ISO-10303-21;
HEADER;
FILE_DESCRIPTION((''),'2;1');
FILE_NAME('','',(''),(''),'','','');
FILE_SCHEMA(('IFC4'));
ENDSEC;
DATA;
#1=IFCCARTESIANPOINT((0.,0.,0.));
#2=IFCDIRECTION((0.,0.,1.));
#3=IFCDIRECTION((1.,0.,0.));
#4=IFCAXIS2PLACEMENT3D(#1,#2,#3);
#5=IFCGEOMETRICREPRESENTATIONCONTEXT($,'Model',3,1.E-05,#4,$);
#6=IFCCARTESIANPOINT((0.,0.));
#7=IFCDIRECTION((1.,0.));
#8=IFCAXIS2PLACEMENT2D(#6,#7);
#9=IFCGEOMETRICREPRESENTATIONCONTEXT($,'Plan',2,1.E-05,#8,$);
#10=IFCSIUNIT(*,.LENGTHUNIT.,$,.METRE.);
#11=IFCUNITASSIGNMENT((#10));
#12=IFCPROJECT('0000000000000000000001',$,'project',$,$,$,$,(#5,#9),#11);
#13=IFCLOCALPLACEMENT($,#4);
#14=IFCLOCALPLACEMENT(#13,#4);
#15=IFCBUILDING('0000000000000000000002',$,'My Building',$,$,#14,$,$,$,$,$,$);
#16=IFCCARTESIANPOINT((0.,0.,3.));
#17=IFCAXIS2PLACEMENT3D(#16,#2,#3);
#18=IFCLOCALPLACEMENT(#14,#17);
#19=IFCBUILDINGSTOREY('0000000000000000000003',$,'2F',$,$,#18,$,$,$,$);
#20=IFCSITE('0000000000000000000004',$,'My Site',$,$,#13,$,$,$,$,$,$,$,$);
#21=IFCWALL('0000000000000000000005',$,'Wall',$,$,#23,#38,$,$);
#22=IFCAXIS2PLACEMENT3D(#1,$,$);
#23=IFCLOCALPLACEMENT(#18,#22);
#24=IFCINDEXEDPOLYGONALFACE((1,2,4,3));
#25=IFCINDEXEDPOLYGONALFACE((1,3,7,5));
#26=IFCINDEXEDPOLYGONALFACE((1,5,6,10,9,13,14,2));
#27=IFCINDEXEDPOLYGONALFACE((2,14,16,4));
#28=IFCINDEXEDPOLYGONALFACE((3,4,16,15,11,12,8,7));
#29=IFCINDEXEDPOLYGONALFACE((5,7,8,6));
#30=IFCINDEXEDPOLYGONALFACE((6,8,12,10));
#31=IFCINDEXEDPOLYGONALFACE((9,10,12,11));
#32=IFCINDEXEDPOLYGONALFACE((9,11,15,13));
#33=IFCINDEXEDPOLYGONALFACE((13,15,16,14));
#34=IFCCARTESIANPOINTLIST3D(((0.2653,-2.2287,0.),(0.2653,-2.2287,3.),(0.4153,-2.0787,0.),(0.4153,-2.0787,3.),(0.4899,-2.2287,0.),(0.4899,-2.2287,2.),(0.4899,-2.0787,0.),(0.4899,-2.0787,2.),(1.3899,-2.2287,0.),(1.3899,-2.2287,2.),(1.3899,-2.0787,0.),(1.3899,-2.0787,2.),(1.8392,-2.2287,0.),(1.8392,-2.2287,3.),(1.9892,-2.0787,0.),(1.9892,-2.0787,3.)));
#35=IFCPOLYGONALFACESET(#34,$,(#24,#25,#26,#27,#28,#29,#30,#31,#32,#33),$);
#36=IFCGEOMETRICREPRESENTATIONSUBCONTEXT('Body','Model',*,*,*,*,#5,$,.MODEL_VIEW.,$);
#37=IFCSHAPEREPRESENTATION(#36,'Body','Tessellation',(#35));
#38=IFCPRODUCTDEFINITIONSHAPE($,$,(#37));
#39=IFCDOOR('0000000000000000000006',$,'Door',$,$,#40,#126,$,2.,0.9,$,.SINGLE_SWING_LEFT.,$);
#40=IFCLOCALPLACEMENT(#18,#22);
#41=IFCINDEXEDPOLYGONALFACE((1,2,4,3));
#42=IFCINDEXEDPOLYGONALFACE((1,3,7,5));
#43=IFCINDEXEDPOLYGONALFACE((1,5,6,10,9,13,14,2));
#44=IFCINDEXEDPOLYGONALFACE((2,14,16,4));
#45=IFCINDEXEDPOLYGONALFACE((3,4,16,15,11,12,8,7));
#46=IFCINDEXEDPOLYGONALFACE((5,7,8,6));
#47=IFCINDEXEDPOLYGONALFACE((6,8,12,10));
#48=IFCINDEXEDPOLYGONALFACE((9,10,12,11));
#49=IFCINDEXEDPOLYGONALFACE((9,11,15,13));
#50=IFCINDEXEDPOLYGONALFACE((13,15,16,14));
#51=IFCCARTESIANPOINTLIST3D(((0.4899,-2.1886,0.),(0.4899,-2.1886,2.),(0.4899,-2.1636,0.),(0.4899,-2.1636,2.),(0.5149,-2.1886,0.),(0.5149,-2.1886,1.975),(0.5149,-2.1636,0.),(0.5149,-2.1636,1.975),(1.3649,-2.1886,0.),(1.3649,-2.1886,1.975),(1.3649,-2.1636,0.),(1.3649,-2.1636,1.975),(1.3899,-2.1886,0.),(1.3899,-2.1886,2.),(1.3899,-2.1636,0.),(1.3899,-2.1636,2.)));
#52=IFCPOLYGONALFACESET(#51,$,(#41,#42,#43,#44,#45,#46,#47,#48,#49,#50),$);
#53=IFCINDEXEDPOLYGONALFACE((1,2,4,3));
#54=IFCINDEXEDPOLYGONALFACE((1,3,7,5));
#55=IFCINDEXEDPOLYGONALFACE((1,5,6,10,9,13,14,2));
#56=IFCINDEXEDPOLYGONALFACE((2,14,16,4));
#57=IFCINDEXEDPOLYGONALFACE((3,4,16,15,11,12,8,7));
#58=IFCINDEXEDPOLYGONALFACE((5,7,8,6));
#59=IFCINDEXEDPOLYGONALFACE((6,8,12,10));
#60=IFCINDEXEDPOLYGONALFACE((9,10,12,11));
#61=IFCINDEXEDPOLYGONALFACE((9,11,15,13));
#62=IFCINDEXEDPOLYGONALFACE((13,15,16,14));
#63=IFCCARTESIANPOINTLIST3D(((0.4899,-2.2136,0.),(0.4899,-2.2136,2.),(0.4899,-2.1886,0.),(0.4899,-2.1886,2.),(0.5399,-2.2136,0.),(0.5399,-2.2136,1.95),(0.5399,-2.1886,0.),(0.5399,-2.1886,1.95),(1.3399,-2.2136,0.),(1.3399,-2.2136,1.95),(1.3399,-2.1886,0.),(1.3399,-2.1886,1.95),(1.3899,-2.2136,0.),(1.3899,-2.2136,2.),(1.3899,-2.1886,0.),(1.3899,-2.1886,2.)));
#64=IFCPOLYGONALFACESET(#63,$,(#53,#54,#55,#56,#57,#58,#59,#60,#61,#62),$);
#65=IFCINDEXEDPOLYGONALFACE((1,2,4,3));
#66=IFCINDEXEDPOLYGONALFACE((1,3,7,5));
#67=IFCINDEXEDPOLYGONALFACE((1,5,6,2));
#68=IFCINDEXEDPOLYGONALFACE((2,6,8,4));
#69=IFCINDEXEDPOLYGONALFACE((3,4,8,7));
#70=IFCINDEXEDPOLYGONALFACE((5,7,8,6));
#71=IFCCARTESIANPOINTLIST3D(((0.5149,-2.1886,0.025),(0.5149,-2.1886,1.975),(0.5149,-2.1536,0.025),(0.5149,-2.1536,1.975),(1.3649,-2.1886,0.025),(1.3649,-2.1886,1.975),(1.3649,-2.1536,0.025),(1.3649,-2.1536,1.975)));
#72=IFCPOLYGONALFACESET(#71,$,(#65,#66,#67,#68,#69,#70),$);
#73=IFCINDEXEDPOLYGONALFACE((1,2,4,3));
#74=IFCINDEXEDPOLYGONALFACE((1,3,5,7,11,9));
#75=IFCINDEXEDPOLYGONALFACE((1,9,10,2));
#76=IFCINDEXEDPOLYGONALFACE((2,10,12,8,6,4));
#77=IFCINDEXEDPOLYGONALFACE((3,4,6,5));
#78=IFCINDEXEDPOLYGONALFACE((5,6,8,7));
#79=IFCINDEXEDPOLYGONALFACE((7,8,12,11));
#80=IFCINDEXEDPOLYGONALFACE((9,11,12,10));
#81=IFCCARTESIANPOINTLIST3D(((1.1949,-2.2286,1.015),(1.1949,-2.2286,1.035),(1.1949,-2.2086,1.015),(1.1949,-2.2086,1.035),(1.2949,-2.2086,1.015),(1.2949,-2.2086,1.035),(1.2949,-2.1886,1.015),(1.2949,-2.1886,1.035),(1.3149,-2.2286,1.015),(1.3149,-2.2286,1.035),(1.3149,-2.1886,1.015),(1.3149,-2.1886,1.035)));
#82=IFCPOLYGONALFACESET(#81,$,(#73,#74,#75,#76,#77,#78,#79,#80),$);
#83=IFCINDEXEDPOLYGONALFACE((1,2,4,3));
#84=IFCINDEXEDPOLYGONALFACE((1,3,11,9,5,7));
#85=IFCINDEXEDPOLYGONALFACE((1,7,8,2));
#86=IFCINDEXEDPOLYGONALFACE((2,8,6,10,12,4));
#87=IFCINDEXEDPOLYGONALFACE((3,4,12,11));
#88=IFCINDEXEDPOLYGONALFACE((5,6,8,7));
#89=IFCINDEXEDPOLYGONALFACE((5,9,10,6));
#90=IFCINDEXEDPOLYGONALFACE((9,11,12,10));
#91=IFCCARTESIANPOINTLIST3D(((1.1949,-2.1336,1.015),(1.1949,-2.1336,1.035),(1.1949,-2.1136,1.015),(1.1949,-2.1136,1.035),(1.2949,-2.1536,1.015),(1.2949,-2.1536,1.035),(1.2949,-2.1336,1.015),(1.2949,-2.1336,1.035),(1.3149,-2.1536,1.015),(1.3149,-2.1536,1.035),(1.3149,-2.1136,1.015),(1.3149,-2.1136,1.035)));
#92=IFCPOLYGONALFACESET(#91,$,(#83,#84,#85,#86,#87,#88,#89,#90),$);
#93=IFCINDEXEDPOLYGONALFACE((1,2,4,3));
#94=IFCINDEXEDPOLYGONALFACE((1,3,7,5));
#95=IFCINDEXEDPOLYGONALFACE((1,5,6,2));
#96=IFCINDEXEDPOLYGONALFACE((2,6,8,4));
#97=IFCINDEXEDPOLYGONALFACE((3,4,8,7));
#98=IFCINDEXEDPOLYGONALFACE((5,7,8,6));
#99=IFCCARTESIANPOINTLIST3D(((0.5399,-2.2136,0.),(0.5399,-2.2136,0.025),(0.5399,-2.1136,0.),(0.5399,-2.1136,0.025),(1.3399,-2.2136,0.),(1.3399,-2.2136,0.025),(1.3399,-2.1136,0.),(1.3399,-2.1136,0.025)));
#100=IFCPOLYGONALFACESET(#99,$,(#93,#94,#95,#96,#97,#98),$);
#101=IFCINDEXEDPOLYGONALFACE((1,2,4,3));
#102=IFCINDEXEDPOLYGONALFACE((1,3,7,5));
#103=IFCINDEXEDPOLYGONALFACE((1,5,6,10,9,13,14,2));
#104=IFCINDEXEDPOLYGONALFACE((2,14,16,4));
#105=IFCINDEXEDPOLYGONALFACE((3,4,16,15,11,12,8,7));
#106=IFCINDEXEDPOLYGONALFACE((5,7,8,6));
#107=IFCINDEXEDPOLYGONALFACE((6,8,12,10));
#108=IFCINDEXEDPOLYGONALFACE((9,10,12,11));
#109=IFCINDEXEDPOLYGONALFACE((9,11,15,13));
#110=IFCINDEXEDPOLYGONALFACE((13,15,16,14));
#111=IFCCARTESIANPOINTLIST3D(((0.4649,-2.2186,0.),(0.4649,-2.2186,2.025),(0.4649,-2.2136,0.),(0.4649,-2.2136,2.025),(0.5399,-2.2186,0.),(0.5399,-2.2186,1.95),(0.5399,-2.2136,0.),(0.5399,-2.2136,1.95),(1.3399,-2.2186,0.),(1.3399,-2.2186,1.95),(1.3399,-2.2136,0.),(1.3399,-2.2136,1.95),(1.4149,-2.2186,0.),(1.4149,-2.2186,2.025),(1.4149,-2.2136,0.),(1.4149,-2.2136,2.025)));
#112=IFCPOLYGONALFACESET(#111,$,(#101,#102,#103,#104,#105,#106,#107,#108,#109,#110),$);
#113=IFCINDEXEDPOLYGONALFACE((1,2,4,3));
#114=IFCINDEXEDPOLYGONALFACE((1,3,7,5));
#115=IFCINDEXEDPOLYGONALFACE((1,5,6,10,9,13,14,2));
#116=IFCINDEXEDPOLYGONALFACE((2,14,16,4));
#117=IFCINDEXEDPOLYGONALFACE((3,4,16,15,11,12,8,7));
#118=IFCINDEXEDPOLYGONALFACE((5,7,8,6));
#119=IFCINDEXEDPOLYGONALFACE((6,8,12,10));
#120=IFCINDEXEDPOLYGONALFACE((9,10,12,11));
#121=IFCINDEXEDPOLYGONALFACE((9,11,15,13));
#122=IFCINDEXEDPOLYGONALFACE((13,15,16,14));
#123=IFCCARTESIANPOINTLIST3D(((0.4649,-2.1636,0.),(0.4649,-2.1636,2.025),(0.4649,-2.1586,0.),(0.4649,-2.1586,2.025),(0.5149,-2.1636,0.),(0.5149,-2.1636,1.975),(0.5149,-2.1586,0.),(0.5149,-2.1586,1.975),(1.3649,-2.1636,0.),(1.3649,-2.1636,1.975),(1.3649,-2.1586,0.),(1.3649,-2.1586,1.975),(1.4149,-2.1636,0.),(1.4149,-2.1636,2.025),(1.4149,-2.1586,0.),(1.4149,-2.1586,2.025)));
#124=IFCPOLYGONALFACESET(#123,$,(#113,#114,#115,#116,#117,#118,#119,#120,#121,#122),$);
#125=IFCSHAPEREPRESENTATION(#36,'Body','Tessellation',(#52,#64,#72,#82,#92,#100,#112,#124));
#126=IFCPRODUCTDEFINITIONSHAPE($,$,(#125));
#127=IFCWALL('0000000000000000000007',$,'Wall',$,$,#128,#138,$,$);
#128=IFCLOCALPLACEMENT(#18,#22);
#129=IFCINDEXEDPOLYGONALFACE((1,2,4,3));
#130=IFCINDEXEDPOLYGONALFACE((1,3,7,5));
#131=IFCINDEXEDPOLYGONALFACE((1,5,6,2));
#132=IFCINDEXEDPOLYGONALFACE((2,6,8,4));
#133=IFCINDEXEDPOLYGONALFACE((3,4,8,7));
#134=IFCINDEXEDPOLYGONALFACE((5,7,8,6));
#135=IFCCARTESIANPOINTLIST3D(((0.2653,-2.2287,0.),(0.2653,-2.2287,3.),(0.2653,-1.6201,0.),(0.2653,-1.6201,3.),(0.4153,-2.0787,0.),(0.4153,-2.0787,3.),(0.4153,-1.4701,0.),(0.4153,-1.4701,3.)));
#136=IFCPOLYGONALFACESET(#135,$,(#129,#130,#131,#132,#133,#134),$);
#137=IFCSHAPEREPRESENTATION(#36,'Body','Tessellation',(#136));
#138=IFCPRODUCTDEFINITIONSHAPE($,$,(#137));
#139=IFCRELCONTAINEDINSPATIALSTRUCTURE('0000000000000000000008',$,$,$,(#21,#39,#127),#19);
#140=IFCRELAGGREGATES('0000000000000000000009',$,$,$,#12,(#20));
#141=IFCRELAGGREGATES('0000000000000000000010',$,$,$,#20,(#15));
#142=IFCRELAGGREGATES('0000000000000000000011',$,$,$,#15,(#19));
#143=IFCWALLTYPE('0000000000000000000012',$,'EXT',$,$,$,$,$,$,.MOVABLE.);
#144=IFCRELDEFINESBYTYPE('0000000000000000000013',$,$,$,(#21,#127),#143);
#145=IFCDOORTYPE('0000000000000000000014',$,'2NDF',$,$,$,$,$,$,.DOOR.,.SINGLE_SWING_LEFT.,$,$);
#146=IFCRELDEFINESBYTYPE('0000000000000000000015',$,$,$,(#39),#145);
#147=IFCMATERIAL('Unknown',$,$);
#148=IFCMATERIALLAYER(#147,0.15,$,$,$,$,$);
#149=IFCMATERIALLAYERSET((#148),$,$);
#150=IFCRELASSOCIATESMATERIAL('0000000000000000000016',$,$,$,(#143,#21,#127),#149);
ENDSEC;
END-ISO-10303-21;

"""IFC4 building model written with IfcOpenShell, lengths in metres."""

from ifc_helpers import new_model, entity, si_unit, frame, origin_with_axes, origin_2d_with_axis, place, context, subcontext, project, spatial, line, indexed_curve, outline, extrude, shape, source, transform, mapped, material, layer, layer_set, layer_usage, type_object, type_shapes, element, fill, save


model = new_model("IFC4")

# Units and contexts
model_context = context("Model", 3, precision=1e-05, world=origin_with_axes())
plan_context = context("Plan", 2, precision=1e-05, world=origin_2d_with_axis())
body_context_1 = subcontext(model_context, "Body", "Model", "MODEL_VIEW")
body_context_2 = subcontext(plan_context, "Body", "Plan", "PLAN_VIEW")
ifc_project = project(units=[si_unit("LENGTHUNIT", "METRE")], contexts=[model_context, plan_context])

# Site, building, storey
site_placement = place(None, origin_with_axes())
site = spatial("IfcSite", under=ifc_project, at=site_placement, Name="My Site")
building_placement = place(site_placement, origin_with_axes())
building = spatial("IfcBuilding", under=site, at=building_placement, Name="My Building")
storey_placement = place(building_placement, frame((0.0, 0.0, 3.0), z_axis=(0.0, 0.0, 1.0), x_axis=(1.0, 0.0, 0.0)))
storey = spatial("IfcBuildingStorey", under=building, at=storey_placement, Name="2F")

# Shared definitions
ifc_material = material(Name="Unknown")

# Shared definitions
ifc_layer_1 = layer(ifc_material, 0.15)
ifc_layer_set_1 = layer_set([ifc_layer_1])
wall_type = type_object("IfcWallType", Name="EXT", PredefinedType="MOVABLE", material=ifc_layer_set_1)

# Wall, opening, door
ifc_layer_usage_1 = layer_usage(ifc_layer_set_1, "AXIS2", "POSITIVE", -0.15)
wall_1_placement = place(storey_placement, frame((1.8392, -2.2287, 0.0), z_axis=(0.0, 0.0, 1.0), x_axis=(-1.0, 0.0, 0.0)))
wall_1 = element("IfcWall", 1, at=wall_1_placement, inside=storey, type_object=wall_type, material=ifc_layer_usage_1, Name="Wall", context=body_context_1, shape_type="SweptSolid", body=[
    extrude(outline(indexed_curve([(-0.15, -0.15), (0.0, 0.0), (1.5739, 0.0), (1.4239, -0.15)], segments=[line(1, 2, 3, 4, 1)])), origin_with_axes(), (0.0, 0.0, 1.0), 3.0),
])
placement_1 = place(storey_placement, frame((0.4899, -2.2136, 0.0), z_axis=(0.0, 0.0, 1.0), x_axis=(1.0, 0.0, 0.0)))
opening_1 = element("IfcOpeningElement", 2, at=placement_1, cuts=wall_1, PredefinedType="OPENING", context=body_context_1, shape_type="SweptSolid", body=[
    extrude(outline(indexed_curve([(0.0, 0.0), (0.9, 0.0), (0.9, 2.0), (0.0, 2.0)], segments=[line(1, 2, 3, 4, 1)])), frame((0.0, -0.6, 0.0), z_axis=(0.0, -1.0, 0.0), x_axis=(1.0, 0.0, 0.0)), (0.0, 0.0, -1.0), 1.2),
])
door_type_1 = type_object("IfcDoorType", Name="2NDF", OperationType="SINGLE_SWING_LEFT", PredefinedType="DOOR")
shared_shape_1 = source(origin_with_axes(), body_context_1, "Body", "SweptSolid", [
    extrude(outline(indexed_curve([(0.0, 0.0), (0.0, 2.0), (0.9, 2.0), (0.9, 0.0), (0.875, 0.0), (0.875, 1.975), (0.025, 1.975), (0.025, 0.0)], segments=[line(1, 2, 3, 4, 5, 6, 7, 8, 1)])), frame((0.0, 0.025, 0.0), z_axis=(0.0, -1.0, 0.0), x_axis=(1.0, 0.0, 0.0)), (0.0, 0.0, -1.0), 0.025),
    extrude(outline(indexed_curve([(0.0, 0.0), (0.0, 2.0), (0.9, 2.0), (0.9, 0.0), (0.85, 0.0), (0.85, 1.95), (0.05, 1.95), (0.05, 0.0)], segments=[line(1, 2, 3, 4, 5, 6, 7, 8, 1)])), frame((0.0, 0.0, 0.0), z_axis=(0.0, -1.0, 0.0), x_axis=(1.0, 0.0, 0.0)), (0.0, 0.0, -1.0), 0.025),
    extrude(outline(indexed_curve([(0.0, 0.0), (0.85, 0.0), (0.85, 0.035), (0.0, 0.035)], segments=[line(1, 2, 3, 4, 1)])), frame((0.025, 0.025, 0.025), z_axis=(0.0, 0.0, 1.0), x_axis=(1.0, 0.0, 0.0)), (0.0, 0.0, 1.0), 1.95),
    extrude(outline(indexed_curve([(0.0, 0.0), (0.0, -0.04), (-0.12, -0.04), (-0.12, -0.02), (-0.02, -0.02), (-0.02, 0.0)], segments=[line(1, 2, 3, 4, 5, 6, 1)])), frame((0.825, 0.025, 1.015), z_axis=(0.0, 0.0, 1.0), x_axis=(1.0, 0.0, 0.0)), (0.0, 0.0, 1.0), 0.02),
    extrude(outline(indexed_curve([(0.0, 0.0), (0.0, 0.04), (-0.12, 0.04), (-0.12, 0.02), (-0.02, 0.02), (-0.02, 0.0)], segments=[line(1, 2, 3, 4, 5, 6, 1)])), frame((0.825, 0.06, 1.015), z_axis=(0.0, 0.0, 1.0), x_axis=(1.0, 0.0, 0.0)), (0.0, 0.0, 1.0), 0.02),
    extrude(outline(indexed_curve([(0.0, 0.0), (0.8, 0.0), (0.8, 0.1), (0.0, 0.1)], segments=[line(1, 2, 3, 4, 1)])), frame((0.05, 0.0, 0.0), z_axis=(0.0, 0.0, 1.0), x_axis=(1.0, 0.0, 0.0)), (0.0, 0.0, 1.0), 0.025),
    extrude(outline(indexed_curve([(0.0, 0.0), (0.0, 2.025), (0.95, 2.025), (0.95, 0.0), (0.875, 0.0), (0.875, 1.95), (0.075, 1.95), (0.075, 0.0)], segments=[line(1, 2, 3, 4, 5, 6, 7, 8, 1)])), frame((-0.025, -0.005, 0.0), z_axis=(0.0, -1.0, 0.0), x_axis=(1.0, 0.0, 0.0)), (0.0, 0.0, -1.0), 0.005),
    extrude(outline(indexed_curve([(0.0, 0.0), (0.0, 2.025), (0.95, 2.025), (0.95, 0.0), (0.9, 0.0), (0.9, 1.975), (0.05, 1.975), (0.05, 0.0)], segments=[line(1, 2, 3, 4, 5, 6, 7, 8, 1)])), frame((-0.025, 0.05, 0.0), z_axis=(0.0, -1.0, 0.0), x_axis=(1.0, 0.0, 0.0)), (0.0, 0.0, -1.0), 0.005),
])
shared_shape_2 = source(origin_with_axes(), body_context_2, "Body", "Curve2D", [
    entity("IfcIndexedPolyCurve", entity("IfcCartesianPointList2D", [[0.0, 0.0], [0.0, 0.05], [0.025, 0.05], [0.025, 0.025], [0.05, 0.025], [0.05, 0.0]]), [entity("IfcLineIndex", [1, 2, 3, 4, 5, 6, 1])]),
    entity("IfcIndexedPolyCurve", entity("IfcCartesianPointList2D", [[0.9, 0.0], [0.9, 0.05], [0.875, 0.05], [0.875, 0.025], [0.85, 0.025], [0.85, 0.0]]), [entity("IfcLineIndex", [1, 2, 3, 4, 5, 6, 1])]),
    entity("IfcTrimmedCurve", entity("IfcEllipse", entity("IfcAxis2Placement2D", entity("IfcCartesianPoint", [0.06, 0.05]), entity("IfcDirection", [1.0, 0.0])), 0.815, 0.85), [entity("IfcCartesianPoint", [0.875, 0.05])], [entity("IfcCartesianPoint", [0.06, 0.9])], True, "CARTESIAN"),
    entity("IfcIndexedPolyCurve", entity("IfcCartesianPointList2D", [[0.025, 0.05], [0.06, 0.05], [0.06, 0.9], [0.025, 0.9]]), [entity("IfcLineIndex", [1, 2, 3, 4, 1])]),
])
type_shapes(door_type_1, [shared_shape_1, shared_shape_2])
door_1 = element("IfcDoor", 3, at=placement_1, inside=storey, type_object=door_type_1, Name="Door", OperationType="SINGLE_SWING_LEFT", OverallHeight=2.0, OverallWidth=0.9, shapes=[
    shape(body_context_1, "Body", "MappedRepresentation", [mapped(shared_shape_1, transform((0.0, 0.0, 0.0), x_axis=(1.0, 0.0, 0.0), y_axis=(0.0, 1.0, 0.0), z_axis=(0.0, 0.0, 1.0), scale=1.0))]),
    shape(body_context_2, "Body", "MappedRepresentation", [mapped(shared_shape_2, transform((0.0, 0.0, 0.0), x_axis=(1.0, 0.0, 0.0), y_axis=(0.0, 1.0, 0.0), z_axis=(0.0, 0.0, 1.0), scale=1.0))]),
])
fill(opening_1, door_1)

# Wall
ifc_layer_usage_2 = layer_usage(ifc_layer_set_1, "AXIS2", "POSITIVE", -0.15)
wall_2_placement = place(storey_placement, frame((0.2653, -2.2287, 0.0), z_axis=(0.0, 0.0, 1.0), x_axis=(0.0, 1.0, 0.0)))
element("IfcWall", 4, at=wall_2_placement, inside=storey, type_object=wall_type, material=ifc_layer_usage_2, Name="Wall", context=body_context_1, shape_type="SweptSolid", body=[
    extrude(outline(indexed_curve([(0.15, -0.15), (0.0, 0.0), (0.6086, 0.0), (0.7586, -0.15)], segments=[line(1, 2, 3, 4, 1)])), origin_with_axes(), (0.0, 0.0, 1.0), 3.0),
])

save(model, "model.ifc")
